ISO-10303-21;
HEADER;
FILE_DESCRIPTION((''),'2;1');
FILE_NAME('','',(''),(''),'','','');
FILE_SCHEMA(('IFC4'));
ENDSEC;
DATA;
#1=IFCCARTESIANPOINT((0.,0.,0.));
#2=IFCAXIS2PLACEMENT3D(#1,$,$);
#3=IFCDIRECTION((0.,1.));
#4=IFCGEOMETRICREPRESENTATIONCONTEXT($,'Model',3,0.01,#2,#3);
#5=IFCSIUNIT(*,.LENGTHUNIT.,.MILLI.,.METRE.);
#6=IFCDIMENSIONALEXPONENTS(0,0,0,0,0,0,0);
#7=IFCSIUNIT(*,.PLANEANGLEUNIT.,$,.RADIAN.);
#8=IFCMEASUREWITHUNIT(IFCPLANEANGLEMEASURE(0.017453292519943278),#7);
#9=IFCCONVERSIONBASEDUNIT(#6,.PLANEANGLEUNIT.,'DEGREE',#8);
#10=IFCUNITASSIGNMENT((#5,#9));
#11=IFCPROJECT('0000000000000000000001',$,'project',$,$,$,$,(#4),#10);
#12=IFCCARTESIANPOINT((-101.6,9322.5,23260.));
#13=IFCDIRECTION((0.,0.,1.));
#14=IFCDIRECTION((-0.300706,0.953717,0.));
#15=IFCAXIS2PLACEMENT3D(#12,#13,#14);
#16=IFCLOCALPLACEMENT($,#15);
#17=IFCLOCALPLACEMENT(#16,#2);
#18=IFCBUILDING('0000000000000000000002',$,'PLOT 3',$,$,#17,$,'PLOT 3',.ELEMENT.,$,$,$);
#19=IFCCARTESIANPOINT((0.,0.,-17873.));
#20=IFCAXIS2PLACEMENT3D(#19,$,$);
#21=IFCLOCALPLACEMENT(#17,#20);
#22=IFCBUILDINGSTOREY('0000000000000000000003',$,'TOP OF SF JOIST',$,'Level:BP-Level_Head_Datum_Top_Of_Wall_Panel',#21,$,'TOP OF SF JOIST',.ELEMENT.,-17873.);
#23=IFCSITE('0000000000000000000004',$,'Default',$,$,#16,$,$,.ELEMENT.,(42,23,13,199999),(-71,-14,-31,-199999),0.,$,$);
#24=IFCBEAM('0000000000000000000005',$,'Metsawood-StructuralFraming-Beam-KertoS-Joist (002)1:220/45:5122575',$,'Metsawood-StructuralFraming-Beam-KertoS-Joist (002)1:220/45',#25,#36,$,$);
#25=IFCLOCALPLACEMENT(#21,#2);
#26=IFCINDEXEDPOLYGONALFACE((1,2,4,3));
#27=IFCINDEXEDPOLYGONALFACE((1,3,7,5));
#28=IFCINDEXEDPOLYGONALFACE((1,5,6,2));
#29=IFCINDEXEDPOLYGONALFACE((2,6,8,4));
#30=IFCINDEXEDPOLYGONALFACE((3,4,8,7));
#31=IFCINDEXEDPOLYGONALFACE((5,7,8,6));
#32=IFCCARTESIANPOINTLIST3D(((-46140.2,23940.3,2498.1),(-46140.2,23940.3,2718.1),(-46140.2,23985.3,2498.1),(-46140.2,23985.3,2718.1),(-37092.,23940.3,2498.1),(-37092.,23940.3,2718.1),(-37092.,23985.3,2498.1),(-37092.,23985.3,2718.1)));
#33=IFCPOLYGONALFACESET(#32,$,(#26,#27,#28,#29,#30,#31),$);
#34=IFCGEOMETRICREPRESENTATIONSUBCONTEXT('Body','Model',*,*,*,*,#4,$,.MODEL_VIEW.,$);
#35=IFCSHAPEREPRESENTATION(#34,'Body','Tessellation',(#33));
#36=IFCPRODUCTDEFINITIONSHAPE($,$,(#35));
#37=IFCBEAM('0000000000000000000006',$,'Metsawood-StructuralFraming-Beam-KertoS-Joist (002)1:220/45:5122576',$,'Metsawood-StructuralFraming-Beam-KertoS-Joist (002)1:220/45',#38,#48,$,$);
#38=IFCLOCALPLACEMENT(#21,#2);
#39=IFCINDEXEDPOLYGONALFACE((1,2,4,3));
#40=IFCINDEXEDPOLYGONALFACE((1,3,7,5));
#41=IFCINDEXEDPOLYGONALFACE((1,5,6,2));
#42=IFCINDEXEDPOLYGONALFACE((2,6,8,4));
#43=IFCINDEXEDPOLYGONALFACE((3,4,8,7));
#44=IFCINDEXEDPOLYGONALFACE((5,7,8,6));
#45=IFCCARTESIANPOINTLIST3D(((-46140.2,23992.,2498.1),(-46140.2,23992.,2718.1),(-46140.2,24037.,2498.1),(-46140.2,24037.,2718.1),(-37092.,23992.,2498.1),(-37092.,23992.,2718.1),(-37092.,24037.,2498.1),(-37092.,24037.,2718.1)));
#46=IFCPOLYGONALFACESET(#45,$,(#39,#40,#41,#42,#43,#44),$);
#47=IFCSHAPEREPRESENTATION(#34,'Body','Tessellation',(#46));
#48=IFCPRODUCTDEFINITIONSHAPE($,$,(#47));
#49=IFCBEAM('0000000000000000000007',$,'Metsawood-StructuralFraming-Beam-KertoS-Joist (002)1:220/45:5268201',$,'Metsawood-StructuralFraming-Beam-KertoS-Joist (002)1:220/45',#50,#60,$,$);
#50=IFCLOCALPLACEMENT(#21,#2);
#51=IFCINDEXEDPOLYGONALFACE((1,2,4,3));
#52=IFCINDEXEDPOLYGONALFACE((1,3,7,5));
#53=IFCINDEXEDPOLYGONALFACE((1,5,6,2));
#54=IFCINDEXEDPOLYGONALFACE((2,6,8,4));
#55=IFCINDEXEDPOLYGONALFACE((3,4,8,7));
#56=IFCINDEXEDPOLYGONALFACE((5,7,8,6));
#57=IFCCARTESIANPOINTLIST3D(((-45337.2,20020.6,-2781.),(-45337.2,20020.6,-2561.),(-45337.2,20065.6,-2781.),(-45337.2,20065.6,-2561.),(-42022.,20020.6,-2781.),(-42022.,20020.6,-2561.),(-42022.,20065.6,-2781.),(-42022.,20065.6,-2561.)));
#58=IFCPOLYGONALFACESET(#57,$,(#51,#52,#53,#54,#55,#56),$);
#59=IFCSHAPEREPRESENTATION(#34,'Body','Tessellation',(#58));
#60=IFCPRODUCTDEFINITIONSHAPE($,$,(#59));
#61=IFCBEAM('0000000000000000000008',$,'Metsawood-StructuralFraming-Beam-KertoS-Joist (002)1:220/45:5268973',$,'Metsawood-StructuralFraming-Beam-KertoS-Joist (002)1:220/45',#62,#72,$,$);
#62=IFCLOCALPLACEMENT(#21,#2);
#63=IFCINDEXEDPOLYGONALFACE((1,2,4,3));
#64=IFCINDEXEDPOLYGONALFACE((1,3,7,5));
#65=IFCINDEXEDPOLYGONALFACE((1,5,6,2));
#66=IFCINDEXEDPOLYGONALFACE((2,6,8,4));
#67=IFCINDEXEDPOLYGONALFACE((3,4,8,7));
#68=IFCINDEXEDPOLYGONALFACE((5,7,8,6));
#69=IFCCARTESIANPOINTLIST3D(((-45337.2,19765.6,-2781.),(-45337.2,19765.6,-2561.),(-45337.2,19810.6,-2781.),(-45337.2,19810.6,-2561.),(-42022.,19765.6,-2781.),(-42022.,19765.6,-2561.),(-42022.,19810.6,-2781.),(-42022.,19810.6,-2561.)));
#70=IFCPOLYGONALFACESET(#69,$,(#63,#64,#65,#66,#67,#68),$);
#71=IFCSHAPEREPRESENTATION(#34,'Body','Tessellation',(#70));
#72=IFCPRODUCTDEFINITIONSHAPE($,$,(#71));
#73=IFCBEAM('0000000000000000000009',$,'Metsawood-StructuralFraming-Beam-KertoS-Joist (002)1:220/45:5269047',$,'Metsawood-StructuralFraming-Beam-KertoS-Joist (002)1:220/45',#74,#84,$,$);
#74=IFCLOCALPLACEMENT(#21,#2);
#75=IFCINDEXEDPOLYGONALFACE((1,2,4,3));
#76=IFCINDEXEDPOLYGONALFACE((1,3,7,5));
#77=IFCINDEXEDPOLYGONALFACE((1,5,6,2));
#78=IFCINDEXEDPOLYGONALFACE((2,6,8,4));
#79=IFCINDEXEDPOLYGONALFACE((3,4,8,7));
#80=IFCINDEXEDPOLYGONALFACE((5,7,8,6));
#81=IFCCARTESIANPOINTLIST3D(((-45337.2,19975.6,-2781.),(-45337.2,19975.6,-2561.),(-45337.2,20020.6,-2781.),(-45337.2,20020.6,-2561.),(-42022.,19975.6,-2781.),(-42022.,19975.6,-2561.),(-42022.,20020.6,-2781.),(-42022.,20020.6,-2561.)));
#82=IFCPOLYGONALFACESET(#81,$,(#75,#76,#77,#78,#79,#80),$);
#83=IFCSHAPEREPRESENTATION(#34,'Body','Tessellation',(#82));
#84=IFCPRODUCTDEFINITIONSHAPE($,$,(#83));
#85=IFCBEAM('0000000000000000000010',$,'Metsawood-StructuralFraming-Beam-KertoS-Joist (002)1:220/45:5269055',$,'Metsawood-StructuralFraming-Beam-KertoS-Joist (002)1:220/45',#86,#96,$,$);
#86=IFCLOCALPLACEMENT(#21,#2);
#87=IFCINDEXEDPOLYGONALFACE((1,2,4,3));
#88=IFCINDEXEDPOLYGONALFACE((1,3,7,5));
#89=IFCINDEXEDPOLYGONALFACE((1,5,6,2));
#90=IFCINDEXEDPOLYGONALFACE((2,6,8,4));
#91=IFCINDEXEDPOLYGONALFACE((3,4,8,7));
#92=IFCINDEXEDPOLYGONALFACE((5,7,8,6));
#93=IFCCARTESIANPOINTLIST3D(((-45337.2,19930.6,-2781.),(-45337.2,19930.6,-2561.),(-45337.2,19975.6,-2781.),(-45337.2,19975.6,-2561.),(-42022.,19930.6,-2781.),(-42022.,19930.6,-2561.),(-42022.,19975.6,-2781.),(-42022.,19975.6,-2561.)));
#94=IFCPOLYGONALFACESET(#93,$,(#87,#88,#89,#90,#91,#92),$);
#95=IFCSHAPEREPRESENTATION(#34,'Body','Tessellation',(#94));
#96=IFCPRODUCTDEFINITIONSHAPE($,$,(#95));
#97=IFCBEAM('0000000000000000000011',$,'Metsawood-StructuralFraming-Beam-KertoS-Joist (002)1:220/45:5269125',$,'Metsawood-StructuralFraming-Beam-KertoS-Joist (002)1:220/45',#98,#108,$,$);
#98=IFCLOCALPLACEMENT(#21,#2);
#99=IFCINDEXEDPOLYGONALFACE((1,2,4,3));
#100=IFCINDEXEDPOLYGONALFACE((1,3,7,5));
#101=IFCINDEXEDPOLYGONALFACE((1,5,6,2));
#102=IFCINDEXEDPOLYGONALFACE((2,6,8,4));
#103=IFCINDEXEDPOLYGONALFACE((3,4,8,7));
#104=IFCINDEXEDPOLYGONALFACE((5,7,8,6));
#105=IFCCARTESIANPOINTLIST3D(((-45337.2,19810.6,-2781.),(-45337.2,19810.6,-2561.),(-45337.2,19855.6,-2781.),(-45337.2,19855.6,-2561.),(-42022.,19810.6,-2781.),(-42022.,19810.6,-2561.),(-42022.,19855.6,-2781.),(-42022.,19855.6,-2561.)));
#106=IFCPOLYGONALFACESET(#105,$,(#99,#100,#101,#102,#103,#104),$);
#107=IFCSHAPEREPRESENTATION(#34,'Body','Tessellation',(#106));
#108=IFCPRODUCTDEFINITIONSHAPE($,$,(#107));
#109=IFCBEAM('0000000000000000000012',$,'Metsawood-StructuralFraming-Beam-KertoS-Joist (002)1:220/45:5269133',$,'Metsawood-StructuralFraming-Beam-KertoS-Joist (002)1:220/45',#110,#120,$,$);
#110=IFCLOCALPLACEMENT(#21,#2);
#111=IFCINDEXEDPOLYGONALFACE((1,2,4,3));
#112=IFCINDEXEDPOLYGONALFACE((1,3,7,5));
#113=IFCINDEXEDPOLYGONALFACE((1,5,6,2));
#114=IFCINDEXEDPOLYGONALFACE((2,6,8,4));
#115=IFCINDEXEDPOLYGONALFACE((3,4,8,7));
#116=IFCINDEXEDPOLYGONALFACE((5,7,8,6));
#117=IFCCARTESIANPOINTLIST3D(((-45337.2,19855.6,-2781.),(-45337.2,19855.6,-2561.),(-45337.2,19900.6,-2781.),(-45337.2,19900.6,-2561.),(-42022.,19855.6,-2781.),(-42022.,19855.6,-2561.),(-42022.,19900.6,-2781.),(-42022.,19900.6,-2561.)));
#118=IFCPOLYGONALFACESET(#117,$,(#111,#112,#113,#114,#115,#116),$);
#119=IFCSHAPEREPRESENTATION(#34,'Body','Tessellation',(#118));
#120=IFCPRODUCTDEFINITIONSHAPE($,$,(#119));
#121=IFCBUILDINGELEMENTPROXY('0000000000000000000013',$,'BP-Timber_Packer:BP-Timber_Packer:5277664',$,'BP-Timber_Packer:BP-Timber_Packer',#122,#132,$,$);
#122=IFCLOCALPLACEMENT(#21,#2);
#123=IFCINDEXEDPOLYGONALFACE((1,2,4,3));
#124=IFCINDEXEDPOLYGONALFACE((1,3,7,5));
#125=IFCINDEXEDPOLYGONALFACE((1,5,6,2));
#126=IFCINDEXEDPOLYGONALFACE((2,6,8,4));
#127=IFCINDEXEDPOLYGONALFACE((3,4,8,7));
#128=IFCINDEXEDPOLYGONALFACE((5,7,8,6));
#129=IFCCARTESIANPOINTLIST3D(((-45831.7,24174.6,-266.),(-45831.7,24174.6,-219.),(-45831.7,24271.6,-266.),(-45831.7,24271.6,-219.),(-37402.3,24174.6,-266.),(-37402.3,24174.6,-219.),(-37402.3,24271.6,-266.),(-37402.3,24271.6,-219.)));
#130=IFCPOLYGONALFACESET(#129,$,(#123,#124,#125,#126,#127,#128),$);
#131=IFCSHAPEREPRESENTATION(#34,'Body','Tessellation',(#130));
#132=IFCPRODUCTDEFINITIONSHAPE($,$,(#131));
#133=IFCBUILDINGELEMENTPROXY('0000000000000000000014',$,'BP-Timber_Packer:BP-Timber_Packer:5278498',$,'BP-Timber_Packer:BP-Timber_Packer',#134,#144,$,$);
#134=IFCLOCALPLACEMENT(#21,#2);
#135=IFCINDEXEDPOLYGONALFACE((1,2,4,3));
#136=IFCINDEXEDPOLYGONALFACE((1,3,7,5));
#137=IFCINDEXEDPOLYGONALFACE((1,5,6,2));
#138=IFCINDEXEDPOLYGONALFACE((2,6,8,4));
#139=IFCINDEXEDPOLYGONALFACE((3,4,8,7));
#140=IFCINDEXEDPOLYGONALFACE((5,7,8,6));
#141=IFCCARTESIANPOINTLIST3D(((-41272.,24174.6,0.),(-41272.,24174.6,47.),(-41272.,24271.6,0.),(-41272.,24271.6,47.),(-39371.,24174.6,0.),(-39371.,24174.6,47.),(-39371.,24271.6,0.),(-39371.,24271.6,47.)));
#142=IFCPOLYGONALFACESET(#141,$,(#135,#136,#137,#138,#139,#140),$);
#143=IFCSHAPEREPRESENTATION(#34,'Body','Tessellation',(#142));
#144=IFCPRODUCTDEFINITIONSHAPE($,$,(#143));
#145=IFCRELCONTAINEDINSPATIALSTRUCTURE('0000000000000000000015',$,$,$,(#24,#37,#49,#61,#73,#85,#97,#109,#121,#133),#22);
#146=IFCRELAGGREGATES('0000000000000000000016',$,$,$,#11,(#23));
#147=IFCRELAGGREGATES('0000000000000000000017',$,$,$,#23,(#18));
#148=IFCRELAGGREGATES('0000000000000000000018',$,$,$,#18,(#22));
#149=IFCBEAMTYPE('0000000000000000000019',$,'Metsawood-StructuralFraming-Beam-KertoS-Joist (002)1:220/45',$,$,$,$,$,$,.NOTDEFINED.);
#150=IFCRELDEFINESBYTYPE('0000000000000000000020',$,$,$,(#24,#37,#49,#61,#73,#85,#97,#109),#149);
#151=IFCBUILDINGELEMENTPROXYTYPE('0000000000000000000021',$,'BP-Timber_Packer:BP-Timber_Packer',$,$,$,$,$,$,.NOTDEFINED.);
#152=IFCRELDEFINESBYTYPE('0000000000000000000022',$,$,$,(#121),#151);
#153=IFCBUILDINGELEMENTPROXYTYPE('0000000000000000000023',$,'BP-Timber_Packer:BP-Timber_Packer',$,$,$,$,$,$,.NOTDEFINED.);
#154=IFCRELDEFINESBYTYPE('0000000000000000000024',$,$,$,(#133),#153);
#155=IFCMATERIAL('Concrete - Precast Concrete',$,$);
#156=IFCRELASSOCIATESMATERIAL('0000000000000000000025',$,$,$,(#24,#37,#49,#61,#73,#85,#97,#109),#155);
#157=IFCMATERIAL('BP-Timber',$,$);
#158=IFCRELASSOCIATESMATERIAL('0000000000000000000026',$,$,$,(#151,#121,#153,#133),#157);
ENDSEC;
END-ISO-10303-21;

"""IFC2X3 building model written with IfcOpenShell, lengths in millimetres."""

from ifc_helpers import new_model, entity, si_unit, converted_unit, direction, frame, frame_2d, origin, origin_2d_with_axis, place, context, subcontext, project, spatial, rectangle, extrude, source, transform, mapped, material, type_object, type_shapes, element, save


model = new_model("IFC2X3")

# Units and contexts
model_context = context("Model", 3, precision=0.01, world=origin(), true_north=direction((0.0, 1.0)))
body_context = subcontext(model_context, "Body", "Model", "MODEL_VIEW")
ifc_project = project(units=[si_unit("LENGTHUNIT", "METRE", prefix="MILLI"), converted_unit("PLANEANGLEUNIT", "DEGREE", entity("IfcPlaneAngleMeasure", 0.017453292519943278), si_unit("PLANEANGLEUNIT", "RADIAN"), dimensions=[0, 0, 0, 0, 0, 0, 0])], contexts=[model_context])

# Site, building, storey
site_placement = place(None, frame((-101.6, 9322.5, 23260.0), z_axis=(0.0, 0.0, 1.0), x_axis=(-0.300706, 0.953717, 0.0)))
site = spatial("IfcSite", under=ifc_project, at=site_placement, Name="Default", CompositionType="ELEMENT", RefLatitude=(42, 23, 13, 199999), RefLongitude=(-71, -14, -31, -199999), RefElevation=0.0)
building_placement = place(site_placement, origin())
building = spatial("IfcBuilding", under=site, at=building_placement, Name="PLOT 3", LongName="PLOT 3", CompositionType="ELEMENT")
storey_placement = place(building_placement, frame((0.0, 0.0, -17873.0)))
storey = spatial("IfcBuildingStorey", under=building, at=storey_placement, Name="TOP OF SF JOIST", ObjectType="Level:BP-Level_Head_Datum_Top_Of_Wall_Panel", LongName="TOP OF SF JOIST", CompositionType="ELEMENT", Elevation=-17873.0)

# Beams
ifc_material_1 = material(Name="Concrete - Precast Concrete")
beam_type = type_object("IfcBeamType", Name="Metsawood-StructuralFraming-Beam-KertoS-Joist (002)1:220/45", PredefinedType="NOTDEFINED")
beam_1_placement = place(storey_placement, frame((-46142.0, 23962.8, 2718.1)))
element("IfcBeam", 1, at=beam_1_placement, inside=storey, type_object=beam_type, material=ifc_material_1, Name="Metsawood-StructuralFraming-Beam-KertoS-Joist (002)1:220/45:5122575", ObjectType="Metsawood-StructuralFraming-Beam-KertoS-Joist (002)1:220/45", context=body_context, shape_type="SweptSolid", body=[
    extrude(rectangle(XDim=220.0, YDim=45.0, at=frame_2d((0.0, 0.0), x_axis=(1.0, 0.0))), frame((1.8, 0.0, -110.0), z_axis=(1.0, 0.0, 0.0), x_axis=(0.0, 0.0, -1.0)), (0.0, 0.0, 1.0), 9048.2),
])
beam_2_placement = place(storey_placement, frame((-46142.0, 24014.5, 2718.1)))
element("IfcBeam", 2, at=beam_2_placement, inside=storey, type_object=beam_type, material=ifc_material_1, Name="Metsawood-StructuralFraming-Beam-KertoS-Joist (002)1:220/45:5122576", ObjectType="Metsawood-StructuralFraming-Beam-KertoS-Joist (002)1:220/45", context=body_context, shape_type="SweptSolid", body=[
    extrude(rectangle(XDim=220.0, YDim=45.0, at=frame_2d((0.0, 0.0), x_axis=(1.0, 0.0))), frame((1.8, 0.0, -110.0), z_axis=(1.0, 0.0, 0.0), x_axis=(0.0, 0.0, -1.0)), (0.0, 0.0, 1.0), 9048.2),
])
beam_3_placement = place(storey_placement, frame((-45339.0, 20043.1, -2561.0)))
element("IfcBeam", 3, at=beam_3_placement, inside=storey, type_object=beam_type, material=ifc_material_1, Name="Metsawood-StructuralFraming-Beam-KertoS-Joist (002)1:220/45:5268201", ObjectType="Metsawood-StructuralFraming-Beam-KertoS-Joist (002)1:220/45", context=body_context, shape_type="SweptSolid", body=[
    extrude(rectangle(XDim=220.0, YDim=45.0, at=frame_2d((0.0, 0.0), x_axis=(1.0, 0.0))), frame((1.8, 0.0, -110.0), z_axis=(1.0, 0.0, 0.0), x_axis=(0.0, 0.0, -1.0)), (0.0, 0.0, 1.0), 3315.2),
])
beam_4_placement = place(storey_placement, frame((-45339.0, 19788.1, -2561.0)))
element("IfcBeam", 4, at=beam_4_placement, inside=storey, type_object=beam_type, material=ifc_material_1, Name="Metsawood-StructuralFraming-Beam-KertoS-Joist (002)1:220/45:5268973", ObjectType="Metsawood-StructuralFraming-Beam-KertoS-Joist (002)1:220/45", context=body_context, shape_type="SweptSolid", body=[
    extrude(rectangle(XDim=220.0, YDim=45.0, at=frame_2d((0.0, 0.0), x_axis=(1.0, 0.0))), frame((1.8, 0.0, -110.0), z_axis=(1.0, 0.0, 0.0), x_axis=(0.0, 0.0, -1.0)), (0.0, 0.0, 1.0), 3315.2),
])
beam_5_placement = place(storey_placement, frame((-45339.0, 19998.1, -2561.0)))
element("IfcBeam", 5, at=beam_5_placement, inside=storey, type_object=beam_type, material=ifc_material_1, Name="Metsawood-StructuralFraming-Beam-KertoS-Joist (002)1:220/45:5269047", ObjectType="Metsawood-StructuralFraming-Beam-KertoS-Joist (002)1:220/45", context=body_context, shape_type="SweptSolid", body=[
    extrude(rectangle(XDim=220.0, YDim=45.0, at=frame_2d((0.0, 0.0), x_axis=(1.0, 0.0))), frame((1.8, 0.0, -110.0), z_axis=(1.0, 0.0, 0.0), x_axis=(0.0, 0.0, -1.0)), (0.0, 0.0, 1.0), 3315.2),
])
beam_6_placement = place(storey_placement, frame((-45339.0, 19953.1, -2561.0)))
element("IfcBeam", 6, at=beam_6_placement, inside=storey, type_object=beam_type, material=ifc_material_1, Name="Metsawood-StructuralFraming-Beam-KertoS-Joist (002)1:220/45:5269055", ObjectType="Metsawood-StructuralFraming-Beam-KertoS-Joist (002)1:220/45", context=body_context, shape_type="SweptSolid", body=[
    extrude(rectangle(XDim=220.0, YDim=45.0, at=frame_2d((0.0, 0.0), x_axis=(1.0, 0.0))), frame((1.8, 0.0, -110.0), z_axis=(1.0, 0.0, 0.0), x_axis=(0.0, 0.0, -1.0)), (0.0, 0.0, 1.0), 3315.2),
])
beam_7_placement = place(storey_placement, frame((-45339.0, 19833.1, -2561.0)))
element("IfcBeam", 7, at=beam_7_placement, inside=storey, type_object=beam_type, material=ifc_material_1, Name="Metsawood-StructuralFraming-Beam-KertoS-Joist (002)1:220/45:5269125", ObjectType="Metsawood-StructuralFraming-Beam-KertoS-Joist (002)1:220/45", context=body_context, shape_type="SweptSolid", body=[
    extrude(rectangle(XDim=220.0, YDim=45.0, at=frame_2d((0.0, 0.0), x_axis=(1.0, 0.0))), frame((1.8, 0.0, -110.0), z_axis=(1.0, 0.0, 0.0), x_axis=(0.0, 0.0, -1.0)), (0.0, 0.0, 1.0), 3315.2),
])
beam_8_placement = place(storey_placement, frame((-45339.0, 19878.1, -2561.0)))
element("IfcBeam", 8, at=beam_8_placement, inside=storey, type_object=beam_type, material=ifc_material_1, Name="Metsawood-StructuralFraming-Beam-KertoS-Joist (002)1:220/45:5269133", ObjectType="Metsawood-StructuralFraming-Beam-KertoS-Joist (002)1:220/45", context=body_context, shape_type="SweptSolid", body=[
    extrude(rectangle(XDim=220.0, YDim=45.0, at=frame_2d((0.0, 0.0), x_axis=(1.0, 0.0))), frame((1.8, 0.0, -110.0), z_axis=(1.0, 0.0, 0.0), x_axis=(0.0, 0.0, -1.0)), (0.0, 0.0, 1.0), 3315.2),
])

# Building element proxies
ifc_material_2 = material(Name="BP-Timber")
building_element_proxy_type_1 = type_object("IfcBuildingElementProxyType", Name="BP-Timber_Packer:BP-Timber_Packer", PredefinedType="NOTDEFINED", material=ifc_material_2)
shared_shape_1 = source(origin(), body_context, "Body", "SweptSolid", [
    extrude(rectangle(XDim=8429.4, YDim=97.0, at=origin_2d_with_axis()), frame((0.0, 0.0, 0.0), z_axis=(0.0, 0.0, 1.0), x_axis=(-1.0, 0.0, 0.0)), (0.0, 0.0, 1.0), 47.0),
])
type_shapes(building_element_proxy_type_1, [shared_shape_1])
proxy_1_placement = place(storey_placement, frame((-41617.0, 24223.1, -266.0)))
element("IfcBuildingElementProxy", 9, at=proxy_1_placement, inside=storey, type_object=building_element_proxy_type_1, material=ifc_material_2, Name="BP-Timber_Packer:BP-Timber_Packer:5277664", ObjectType="BP-Timber_Packer:BP-Timber_Packer", context=body_context, shape_type="MappedRepresentation", body=[
    mapped(shared_shape_1, transform((0.0, 0.0, 0.0), scale=1.0)),
])
building_element_proxy_type_2 = type_object("IfcBuildingElementProxyType", Name="BP-Timber_Packer:BP-Timber_Packer", PredefinedType="NOTDEFINED", material=ifc_material_2)
shared_shape_2 = source(origin(), body_context, "Body", "SweptSolid", [
    extrude(rectangle(XDim=1901.0, YDim=97.0, at=origin_2d_with_axis()), frame((0.0, 0.0, 0.0), z_axis=(0.0, 0.0, 1.0), x_axis=(-1.0, 0.0, 0.0)), (0.0, 0.0, 1.0), 47.0),
])
type_shapes(building_element_proxy_type_2, [shared_shape_2])
proxy_2_placement = place(storey_placement, frame((-40321.5, 24223.1, 0.0)))
element("IfcBuildingElementProxy", 10, at=proxy_2_placement, inside=storey, type_object=building_element_proxy_type_2, material=ifc_material_2, Name="BP-Timber_Packer:BP-Timber_Packer:5278498", ObjectType="BP-Timber_Packer:BP-Timber_Packer", context=body_context, shape_type="MappedRepresentation", body=[
    mapped(shared_shape_2, transform((0.0, 0.0, 0.0), scale=1.0)),
])

save(model, "model.ifc")
